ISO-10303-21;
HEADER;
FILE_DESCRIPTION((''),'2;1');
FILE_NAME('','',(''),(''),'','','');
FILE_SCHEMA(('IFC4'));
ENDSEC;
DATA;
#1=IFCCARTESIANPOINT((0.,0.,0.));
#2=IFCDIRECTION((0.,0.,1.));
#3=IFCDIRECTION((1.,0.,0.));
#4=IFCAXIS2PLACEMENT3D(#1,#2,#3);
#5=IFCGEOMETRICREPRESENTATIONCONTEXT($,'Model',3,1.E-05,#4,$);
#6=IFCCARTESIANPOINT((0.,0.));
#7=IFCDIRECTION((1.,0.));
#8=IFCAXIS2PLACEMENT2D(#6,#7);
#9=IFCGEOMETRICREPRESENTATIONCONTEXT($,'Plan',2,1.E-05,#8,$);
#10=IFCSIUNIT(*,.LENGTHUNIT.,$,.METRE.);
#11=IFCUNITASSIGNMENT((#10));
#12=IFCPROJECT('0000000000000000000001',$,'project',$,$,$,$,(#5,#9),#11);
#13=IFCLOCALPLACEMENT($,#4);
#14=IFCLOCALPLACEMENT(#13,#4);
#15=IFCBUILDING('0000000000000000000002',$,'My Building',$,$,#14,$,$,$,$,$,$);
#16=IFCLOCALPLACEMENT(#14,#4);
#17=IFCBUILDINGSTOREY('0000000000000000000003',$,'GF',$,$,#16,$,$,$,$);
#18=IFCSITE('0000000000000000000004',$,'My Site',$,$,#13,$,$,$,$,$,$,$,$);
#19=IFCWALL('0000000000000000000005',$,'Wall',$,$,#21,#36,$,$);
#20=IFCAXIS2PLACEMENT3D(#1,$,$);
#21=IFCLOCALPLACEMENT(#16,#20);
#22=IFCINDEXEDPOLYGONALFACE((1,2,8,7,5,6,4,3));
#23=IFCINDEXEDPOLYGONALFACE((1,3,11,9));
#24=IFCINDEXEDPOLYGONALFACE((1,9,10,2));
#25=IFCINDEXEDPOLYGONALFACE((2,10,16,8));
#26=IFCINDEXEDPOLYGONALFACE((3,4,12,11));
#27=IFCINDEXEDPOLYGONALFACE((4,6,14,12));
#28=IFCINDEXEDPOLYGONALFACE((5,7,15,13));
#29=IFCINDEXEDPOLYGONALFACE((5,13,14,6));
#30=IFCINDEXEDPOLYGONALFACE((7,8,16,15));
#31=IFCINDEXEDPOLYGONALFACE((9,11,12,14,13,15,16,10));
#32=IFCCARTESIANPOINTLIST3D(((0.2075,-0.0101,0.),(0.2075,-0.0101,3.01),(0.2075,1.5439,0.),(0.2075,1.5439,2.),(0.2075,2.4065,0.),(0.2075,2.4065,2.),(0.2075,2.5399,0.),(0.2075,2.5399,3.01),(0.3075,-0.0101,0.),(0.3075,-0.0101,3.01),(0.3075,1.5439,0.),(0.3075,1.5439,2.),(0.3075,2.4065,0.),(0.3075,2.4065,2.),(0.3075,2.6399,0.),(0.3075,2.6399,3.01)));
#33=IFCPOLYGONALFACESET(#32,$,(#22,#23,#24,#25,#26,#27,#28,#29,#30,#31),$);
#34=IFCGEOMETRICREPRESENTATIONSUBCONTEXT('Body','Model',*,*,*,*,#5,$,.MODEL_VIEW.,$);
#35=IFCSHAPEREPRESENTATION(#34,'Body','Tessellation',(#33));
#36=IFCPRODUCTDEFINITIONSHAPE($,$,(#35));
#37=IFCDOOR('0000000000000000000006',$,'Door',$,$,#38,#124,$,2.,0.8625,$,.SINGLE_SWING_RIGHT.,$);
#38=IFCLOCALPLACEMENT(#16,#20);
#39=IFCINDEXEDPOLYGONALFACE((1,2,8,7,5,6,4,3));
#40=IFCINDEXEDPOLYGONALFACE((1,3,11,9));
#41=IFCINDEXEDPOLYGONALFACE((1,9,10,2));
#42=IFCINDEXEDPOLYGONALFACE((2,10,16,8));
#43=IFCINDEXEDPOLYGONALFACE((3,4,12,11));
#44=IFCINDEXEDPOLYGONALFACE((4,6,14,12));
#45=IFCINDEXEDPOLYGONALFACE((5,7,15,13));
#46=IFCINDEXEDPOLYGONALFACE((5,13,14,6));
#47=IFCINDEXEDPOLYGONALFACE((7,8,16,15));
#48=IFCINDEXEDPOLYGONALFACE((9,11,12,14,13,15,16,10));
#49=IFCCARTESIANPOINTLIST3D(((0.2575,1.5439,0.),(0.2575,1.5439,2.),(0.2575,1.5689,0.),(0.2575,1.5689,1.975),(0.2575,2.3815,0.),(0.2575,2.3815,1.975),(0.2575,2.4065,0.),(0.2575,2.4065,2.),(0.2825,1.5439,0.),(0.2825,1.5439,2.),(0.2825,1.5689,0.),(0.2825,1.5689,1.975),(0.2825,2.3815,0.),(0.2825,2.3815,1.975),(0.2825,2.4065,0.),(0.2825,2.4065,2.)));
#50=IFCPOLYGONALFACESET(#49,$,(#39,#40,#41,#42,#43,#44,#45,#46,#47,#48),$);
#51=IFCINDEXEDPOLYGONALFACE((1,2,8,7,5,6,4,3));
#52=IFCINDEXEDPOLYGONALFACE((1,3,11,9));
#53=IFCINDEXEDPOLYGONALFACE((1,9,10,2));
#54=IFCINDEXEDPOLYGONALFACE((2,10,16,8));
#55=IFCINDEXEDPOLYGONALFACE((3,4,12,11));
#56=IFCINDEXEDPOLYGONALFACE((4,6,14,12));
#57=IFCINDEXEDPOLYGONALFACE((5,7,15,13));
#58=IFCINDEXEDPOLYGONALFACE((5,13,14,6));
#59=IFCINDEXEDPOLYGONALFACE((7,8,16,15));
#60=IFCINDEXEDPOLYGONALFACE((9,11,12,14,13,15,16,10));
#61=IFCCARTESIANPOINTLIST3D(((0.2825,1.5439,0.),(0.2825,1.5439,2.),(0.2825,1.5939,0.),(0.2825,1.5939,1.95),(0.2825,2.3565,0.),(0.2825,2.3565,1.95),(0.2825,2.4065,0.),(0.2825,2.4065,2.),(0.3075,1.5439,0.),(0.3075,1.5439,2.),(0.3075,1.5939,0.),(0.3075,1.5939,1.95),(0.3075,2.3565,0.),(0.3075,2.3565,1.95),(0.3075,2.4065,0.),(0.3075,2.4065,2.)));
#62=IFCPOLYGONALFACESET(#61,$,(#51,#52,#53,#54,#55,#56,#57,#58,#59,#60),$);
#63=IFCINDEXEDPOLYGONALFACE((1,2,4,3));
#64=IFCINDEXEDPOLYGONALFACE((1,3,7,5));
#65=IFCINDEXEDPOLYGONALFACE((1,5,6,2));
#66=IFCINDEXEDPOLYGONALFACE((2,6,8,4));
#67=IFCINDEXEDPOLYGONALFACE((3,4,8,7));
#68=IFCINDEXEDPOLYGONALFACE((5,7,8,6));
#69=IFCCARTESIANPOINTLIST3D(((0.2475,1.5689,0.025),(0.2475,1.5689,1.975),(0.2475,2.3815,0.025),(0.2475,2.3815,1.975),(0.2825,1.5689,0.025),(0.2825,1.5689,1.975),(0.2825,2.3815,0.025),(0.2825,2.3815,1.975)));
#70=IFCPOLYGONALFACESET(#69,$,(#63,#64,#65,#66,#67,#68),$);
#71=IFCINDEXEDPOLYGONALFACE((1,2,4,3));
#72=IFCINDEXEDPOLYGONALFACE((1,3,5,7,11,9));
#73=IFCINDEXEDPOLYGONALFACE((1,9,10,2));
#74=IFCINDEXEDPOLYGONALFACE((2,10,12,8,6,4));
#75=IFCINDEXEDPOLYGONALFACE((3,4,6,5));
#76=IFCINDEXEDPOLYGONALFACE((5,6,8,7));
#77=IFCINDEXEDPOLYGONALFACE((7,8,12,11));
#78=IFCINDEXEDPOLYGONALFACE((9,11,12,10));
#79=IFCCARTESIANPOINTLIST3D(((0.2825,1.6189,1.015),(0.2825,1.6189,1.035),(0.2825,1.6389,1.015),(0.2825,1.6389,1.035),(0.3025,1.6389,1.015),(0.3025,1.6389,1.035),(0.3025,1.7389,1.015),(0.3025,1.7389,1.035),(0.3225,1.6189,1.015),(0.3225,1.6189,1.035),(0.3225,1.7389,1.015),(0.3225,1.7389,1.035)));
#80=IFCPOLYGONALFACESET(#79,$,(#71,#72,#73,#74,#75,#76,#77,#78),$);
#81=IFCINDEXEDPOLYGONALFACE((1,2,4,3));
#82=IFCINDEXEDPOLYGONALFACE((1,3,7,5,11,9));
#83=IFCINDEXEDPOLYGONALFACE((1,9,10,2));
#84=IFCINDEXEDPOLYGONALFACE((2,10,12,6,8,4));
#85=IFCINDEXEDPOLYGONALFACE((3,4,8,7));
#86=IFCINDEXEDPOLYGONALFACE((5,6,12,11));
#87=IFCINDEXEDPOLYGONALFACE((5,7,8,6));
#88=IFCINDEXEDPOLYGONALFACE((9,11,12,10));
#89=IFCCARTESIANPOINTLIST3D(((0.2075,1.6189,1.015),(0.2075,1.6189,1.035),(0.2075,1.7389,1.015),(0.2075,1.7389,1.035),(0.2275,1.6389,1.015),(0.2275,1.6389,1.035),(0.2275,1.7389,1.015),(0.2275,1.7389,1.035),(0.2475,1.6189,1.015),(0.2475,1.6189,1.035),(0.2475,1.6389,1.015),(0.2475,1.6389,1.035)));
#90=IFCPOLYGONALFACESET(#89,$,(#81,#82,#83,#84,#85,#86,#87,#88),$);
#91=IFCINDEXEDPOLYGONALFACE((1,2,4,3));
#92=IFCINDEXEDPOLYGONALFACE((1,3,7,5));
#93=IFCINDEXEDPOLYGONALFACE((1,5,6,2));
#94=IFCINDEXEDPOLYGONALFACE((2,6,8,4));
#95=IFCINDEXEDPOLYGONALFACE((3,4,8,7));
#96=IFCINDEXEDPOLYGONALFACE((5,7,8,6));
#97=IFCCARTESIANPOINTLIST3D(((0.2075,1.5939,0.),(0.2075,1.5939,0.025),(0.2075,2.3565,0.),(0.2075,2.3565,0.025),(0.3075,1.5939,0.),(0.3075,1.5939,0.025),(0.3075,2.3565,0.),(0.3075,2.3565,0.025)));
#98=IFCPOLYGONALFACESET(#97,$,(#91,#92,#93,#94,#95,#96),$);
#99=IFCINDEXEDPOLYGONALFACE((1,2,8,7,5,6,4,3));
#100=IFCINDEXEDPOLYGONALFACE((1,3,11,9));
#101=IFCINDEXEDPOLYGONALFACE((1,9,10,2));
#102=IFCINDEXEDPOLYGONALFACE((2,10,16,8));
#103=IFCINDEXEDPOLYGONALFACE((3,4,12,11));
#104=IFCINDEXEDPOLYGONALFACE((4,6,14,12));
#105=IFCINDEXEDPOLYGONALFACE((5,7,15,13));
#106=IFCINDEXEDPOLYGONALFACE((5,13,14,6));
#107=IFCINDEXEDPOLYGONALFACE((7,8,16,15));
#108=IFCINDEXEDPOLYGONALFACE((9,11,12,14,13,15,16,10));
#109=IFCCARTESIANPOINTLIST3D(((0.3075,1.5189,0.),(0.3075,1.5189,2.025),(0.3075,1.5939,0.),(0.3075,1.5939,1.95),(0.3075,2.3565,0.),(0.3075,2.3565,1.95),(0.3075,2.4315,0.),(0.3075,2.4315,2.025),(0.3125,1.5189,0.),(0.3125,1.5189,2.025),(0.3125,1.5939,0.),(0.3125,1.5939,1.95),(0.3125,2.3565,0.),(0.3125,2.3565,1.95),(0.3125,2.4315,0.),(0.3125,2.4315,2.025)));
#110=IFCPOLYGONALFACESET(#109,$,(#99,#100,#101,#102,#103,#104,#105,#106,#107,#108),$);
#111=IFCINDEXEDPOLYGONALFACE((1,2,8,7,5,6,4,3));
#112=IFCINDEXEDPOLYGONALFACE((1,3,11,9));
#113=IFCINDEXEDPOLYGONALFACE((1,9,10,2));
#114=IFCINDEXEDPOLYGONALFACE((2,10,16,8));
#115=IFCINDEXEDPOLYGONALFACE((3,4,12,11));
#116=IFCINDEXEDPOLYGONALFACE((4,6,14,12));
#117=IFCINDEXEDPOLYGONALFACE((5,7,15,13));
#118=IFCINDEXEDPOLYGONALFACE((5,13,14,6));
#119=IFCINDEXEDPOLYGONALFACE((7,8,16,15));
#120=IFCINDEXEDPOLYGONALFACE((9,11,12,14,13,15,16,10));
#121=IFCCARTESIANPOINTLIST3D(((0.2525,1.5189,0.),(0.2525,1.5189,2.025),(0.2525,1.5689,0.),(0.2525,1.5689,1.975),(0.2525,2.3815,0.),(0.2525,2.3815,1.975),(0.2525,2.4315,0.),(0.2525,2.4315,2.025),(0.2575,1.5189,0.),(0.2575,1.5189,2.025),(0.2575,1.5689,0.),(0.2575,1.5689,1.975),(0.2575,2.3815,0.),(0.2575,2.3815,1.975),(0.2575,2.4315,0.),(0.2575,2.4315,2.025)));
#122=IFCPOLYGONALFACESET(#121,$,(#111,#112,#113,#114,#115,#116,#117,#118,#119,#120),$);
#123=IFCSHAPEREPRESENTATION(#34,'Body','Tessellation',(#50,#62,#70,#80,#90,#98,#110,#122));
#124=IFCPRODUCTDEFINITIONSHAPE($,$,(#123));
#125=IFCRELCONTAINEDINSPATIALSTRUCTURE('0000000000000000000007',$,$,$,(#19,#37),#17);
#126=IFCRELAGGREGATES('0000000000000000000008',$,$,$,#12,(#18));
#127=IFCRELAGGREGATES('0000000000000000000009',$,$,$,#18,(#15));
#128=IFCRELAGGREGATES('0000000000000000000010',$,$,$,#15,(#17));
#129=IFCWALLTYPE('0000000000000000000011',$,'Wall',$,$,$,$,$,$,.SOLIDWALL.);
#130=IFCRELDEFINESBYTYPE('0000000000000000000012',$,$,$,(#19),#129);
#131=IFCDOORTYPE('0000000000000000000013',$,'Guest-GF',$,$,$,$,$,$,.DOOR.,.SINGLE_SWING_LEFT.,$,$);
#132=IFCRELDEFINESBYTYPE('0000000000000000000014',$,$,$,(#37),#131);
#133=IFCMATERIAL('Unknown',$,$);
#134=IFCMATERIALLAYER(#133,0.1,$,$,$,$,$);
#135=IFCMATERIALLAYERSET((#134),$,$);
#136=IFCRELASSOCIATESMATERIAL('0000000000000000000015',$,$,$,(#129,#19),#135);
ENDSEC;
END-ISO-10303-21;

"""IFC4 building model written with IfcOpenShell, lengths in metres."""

from ifc_helpers import new_model, entity, si_unit, frame, origin_with_axes, origin_2d_with_axis, place, context, subcontext, project, spatial, line, indexed_curve, outline, extrude, shape, source, transform, mapped, material, layer, layer_set, layer_usage, type_object, type_shapes, element, fill, save


model = new_model("IFC4")

# Units and contexts
model_context = context("Model", 3, precision=1e-05, world=origin_with_axes())
plan_context = context("Plan", 2, precision=1e-05, world=origin_2d_with_axis())
body_context_1 = subcontext(model_context, "Body", "Model", "MODEL_VIEW")
body_context_2 = subcontext(plan_context, "Body", "Plan", "PLAN_VIEW")
ifc_project = project(units=[si_unit("LENGTHUNIT", "METRE")], contexts=[model_context, plan_context])

# Site, building, storey
site_placement = place(None, origin_with_axes())
site = spatial("IfcSite", under=ifc_project, at=site_placement, Name="My Site")
building_placement = place(site_placement, origin_with_axes())
building = spatial("IfcBuilding", under=site, at=building_placement, Name="My Building")
storey_placement = place(building_placement, origin_with_axes())
storey = spatial("IfcBuildingStorey", under=building, at=storey_placement, Name="GF")

# Shared definitions
ifc_material = material(Name="Unknown")

# Shared definitions
ifc_layer_1 = layer(ifc_material, 0.1)
ifc_layer_set_1 = layer_set([ifc_layer_1])
wall_type = type_object("IfcWallType", Name="Wall", PredefinedType="SOLIDWALL", material=ifc_layer_set_1)

# Wall, opening, door
ifc_layer_usage_1 = layer_usage(ifc_layer_set_1, "AXIS2", "POSITIVE", 0.0)
wall_1_placement = place(storey_placement, frame((0.3075, -0.0101, 0.0), z_axis=(0.0, 0.0, 1.0), x_axis=(0.0, 1.0, 0.0)))
wall_1 = element("IfcWall", 1, at=wall_1_placement, inside=storey, type_object=wall_type, material=ifc_layer_usage_1, Name="Wall", context=body_context_1, shape_type="SweptSolid", body=[
    extrude(outline(indexed_curve([(0.0, 0.0), (0.0, 0.1), (2.55, 0.1), (2.65, 0.0)], segments=[line(1, 2, 3, 4, 1)])), origin_with_axes(), (0.0, 0.0, 1.0), 3.01),
])
shared_shape_1 = source(origin_with_axes(), body_context_1, "Body", "SweptSolid", [
    extrude(outline(indexed_curve([(0.0, 0.0), (0.8625, 0.0), (0.8625, 2.0), (0.0, 2.0)], segments=[line(1, 2, 3, 4, 1)])), frame((0.0, -0.6, 0.0), z_axis=(0.0, -1.0, 0.0), x_axis=(1.0, 0.0, 0.0)), (0.0, 0.0, -1.0), 1.2),
])
opening_1_placement = place(wall_1_placement, frame((1.554, 0.0, 0.0), z_axis=(0.0, 0.0, 1.0), x_axis=(1.0, 0.0, 0.0)))
opening_1 = element("IfcOpeningElement", 2, at=opening_1_placement, cuts=wall_1, PredefinedType="OPENING", context=body_context_1, shape_type="MappedRepresentation", body=[
    mapped(shared_shape_1, transform((0.0, 0.0, 0.0), x_axis=(1.0, 0.0, 0.0), y_axis=(0.0, 1.0, 0.0), z_axis=(0.0, 0.0, 1.0), scale=1.0)),
])
door_type_1 = type_object("IfcDoorType", Name="Guest-GF", OperationType="SINGLE_SWING_LEFT", PredefinedType="DOOR")
shared_shape_2 = source(origin_with_axes(), body_context_1, "Body", "SweptSolid", [
    extrude(outline(indexed_curve([(0.0, 0.0), (0.0, 2.0), (0.8625, 2.0), (0.8625, 0.0), (0.8375, 0.0), (0.8375, 1.975), (0.025, 1.975), (0.025, 0.0)], segments=[line(1, 2, 3, 4, 5, 6, 7, 8, 1)])), frame((0.0, 0.025, 0.0), z_axis=(0.0, -1.0, 0.0), x_axis=(1.0, 0.0, 0.0)), (0.0, 0.0, -1.0), 0.025),
    extrude(outline(indexed_curve([(0.0, 0.0), (0.0, 2.0), (0.8625, 2.0), (0.8625, 0.0), (0.8125, 0.0), (0.8125, 1.95), (0.05, 1.95), (0.05, 0.0)], segments=[line(1, 2, 3, 4, 5, 6, 7, 8, 1)])), frame((0.0, 0.0, 0.0), z_axis=(0.0, -1.0, 0.0), x_axis=(1.0, 0.0, 0.0)), (0.0, 0.0, -1.0), 0.025),
    extrude(outline(indexed_curve([(0.0, 0.0), (0.8125, 0.0), (0.8125, 0.035), (0.0, 0.035)], segments=[line(1, 2, 3, 4, 1)])), frame((0.025, 0.025, 0.025), z_axis=(0.0, 0.0, 1.0), x_axis=(1.0, 0.0, 0.0)), (0.0, 0.0, 1.0), 1.95),
    extrude(outline(indexed_curve([(0.0, 0.0), (0.0, -0.04), (0.12, -0.04), (0.12, -0.02), (0.02, -0.02), (0.02, 0.0)], segments=[line(1, 2, 3, 4, 5, 6, 1)])), frame((0.075, 0.025, 1.015), z_axis=(0.0, 0.0, 1.0), x_axis=(1.0, 0.0, 0.0)), (0.0, 0.0, 1.0), 0.02),
    extrude(outline(indexed_curve([(0.0, 0.0), (0.0, 0.04), (0.12, 0.04), (0.12, 0.02), (0.02, 0.02), (0.02, 0.0)], segments=[line(1, 2, 3, 4, 5, 6, 1)])), frame((0.075, 0.06, 1.015), z_axis=(0.0, 0.0, 1.0), x_axis=(1.0, 0.0, 0.0)), (0.0, 0.0, 1.0), 0.02),
    extrude(outline(indexed_curve([(0.0, 0.0), (0.7625, 0.0), (0.7625, 0.1), (0.0, 0.1)], segments=[line(1, 2, 3, 4, 1)])), frame((0.05, 0.0, 0.0), z_axis=(0.0, 0.0, 1.0), x_axis=(1.0, 0.0, 0.0)), (0.0, 0.0, 1.0), 0.025),
    extrude(outline(indexed_curve([(0.0, 0.0), (0.0, 2.025), (0.9125, 2.025), (0.9125, 0.0), (0.8375, 0.0), (0.8375, 1.95), (0.075, 1.95), (0.075, 0.0)], segments=[line(1, 2, 3, 4, 5, 6, 7, 8, 1)])), frame((-0.025, -0.005, 0.0), z_axis=(0.0, -1.0, 0.0), x_axis=(1.0, 0.0, 0.0)), (0.0, 0.0, -1.0), 0.005),
    extrude(outline(indexed_curve([(0.0, 0.0), (0.0, 2.025), (0.9125, 2.025), (0.9125, 0.0), (0.8625, 0.0), (0.8625, 1.975), (0.05, 1.975), (0.05, 0.0)], segments=[line(1, 2, 3, 4, 5, 6, 7, 8, 1)])), frame((-0.025, 0.05, 0.0), z_axis=(0.0, -1.0, 0.0), x_axis=(1.0, 0.0, 0.0)), (0.0, 0.0, -1.0), 0.005),
])
shared_shape_3 = source(origin_with_axes(), body_context_2, "Body", "Curve2D", [
    entity("IfcIndexedPolyCurve", entity("IfcCartesianPointList2D", [[0.0, 0.0], [0.0, 0.05], [0.025, 0.05], [0.025, 0.025], [0.05, 0.025], [0.05, 0.0]]), [entity("IfcLineIndex", [1, 2, 3, 4, 5, 6, 1])]),
    entity("IfcIndexedPolyCurve", entity("IfcCartesianPointList2D", [[0.8625, 0.0], [0.8625, 0.05], [0.8375, 0.05], [0.8375, 0.025], [0.8125, 0.025], [0.8125, 0.0]]), [entity("IfcLineIndex", [1, 2, 3, 4, 5, 6, 1])]),
    entity("IfcTrimmedCurve", entity("IfcEllipse", entity("IfcAxis2Placement2D", entity("IfcCartesianPoint", [0.8025, 0.05]), entity("IfcDirection", [1.0, 0.0])), 0.7775, 0.8125), [entity("IfcCartesianPoint", [0.8025, 0.8625])], [entity("IfcCartesianPoint", [0.025, 0.05])], True, "CARTESIAN"),
    entity("IfcIndexedPolyCurve", entity("IfcCartesianPointList2D", [[0.8375, 0.05], [0.8025, 0.05], [0.8025, 0.8625], [0.8375, 0.8625]]), [entity("IfcLineIndex", [1, 2, 3, 4, 1])]),
])
type_shapes(door_type_1, [shared_shape_2, shared_shape_3])
door_1_placement = place(opening_1_placement, frame((0.0, 0.0, 0.0), z_axis=(0.0, 0.0, 1.0), x_axis=(1.0, 0.0, 0.0)))
door_1 = element("IfcDoor", 3, at=door_1_placement, inside=storey, type_object=door_type_1, Name="Door", OperationType="SINGLE_SWING_RIGHT", OverallHeight=2.0, OverallWidth=0.8625, shapes=[
    shape(body_context_1, "Body", "MappedRepresentation", [mapped(shared_shape_2, transform((0.0, 0.0, 0.0), x_axis=(1.0, 0.0, 0.0), y_axis=(0.0, 1.0, 0.0), z_axis=(0.0, 0.0, 1.0), scale=1.0))]),
    shape(body_context_2, "Body", "MappedRepresentation", [mapped(shared_shape_3, transform((0.0, 0.0, 0.0), x_axis=(1.0, 0.0, 0.0), y_axis=(0.0, 1.0, 0.0), z_axis=(0.0, 0.0, 1.0), scale=1.0))]),
])
fill(opening_1, door_1)

save(model, "model.ifc")
